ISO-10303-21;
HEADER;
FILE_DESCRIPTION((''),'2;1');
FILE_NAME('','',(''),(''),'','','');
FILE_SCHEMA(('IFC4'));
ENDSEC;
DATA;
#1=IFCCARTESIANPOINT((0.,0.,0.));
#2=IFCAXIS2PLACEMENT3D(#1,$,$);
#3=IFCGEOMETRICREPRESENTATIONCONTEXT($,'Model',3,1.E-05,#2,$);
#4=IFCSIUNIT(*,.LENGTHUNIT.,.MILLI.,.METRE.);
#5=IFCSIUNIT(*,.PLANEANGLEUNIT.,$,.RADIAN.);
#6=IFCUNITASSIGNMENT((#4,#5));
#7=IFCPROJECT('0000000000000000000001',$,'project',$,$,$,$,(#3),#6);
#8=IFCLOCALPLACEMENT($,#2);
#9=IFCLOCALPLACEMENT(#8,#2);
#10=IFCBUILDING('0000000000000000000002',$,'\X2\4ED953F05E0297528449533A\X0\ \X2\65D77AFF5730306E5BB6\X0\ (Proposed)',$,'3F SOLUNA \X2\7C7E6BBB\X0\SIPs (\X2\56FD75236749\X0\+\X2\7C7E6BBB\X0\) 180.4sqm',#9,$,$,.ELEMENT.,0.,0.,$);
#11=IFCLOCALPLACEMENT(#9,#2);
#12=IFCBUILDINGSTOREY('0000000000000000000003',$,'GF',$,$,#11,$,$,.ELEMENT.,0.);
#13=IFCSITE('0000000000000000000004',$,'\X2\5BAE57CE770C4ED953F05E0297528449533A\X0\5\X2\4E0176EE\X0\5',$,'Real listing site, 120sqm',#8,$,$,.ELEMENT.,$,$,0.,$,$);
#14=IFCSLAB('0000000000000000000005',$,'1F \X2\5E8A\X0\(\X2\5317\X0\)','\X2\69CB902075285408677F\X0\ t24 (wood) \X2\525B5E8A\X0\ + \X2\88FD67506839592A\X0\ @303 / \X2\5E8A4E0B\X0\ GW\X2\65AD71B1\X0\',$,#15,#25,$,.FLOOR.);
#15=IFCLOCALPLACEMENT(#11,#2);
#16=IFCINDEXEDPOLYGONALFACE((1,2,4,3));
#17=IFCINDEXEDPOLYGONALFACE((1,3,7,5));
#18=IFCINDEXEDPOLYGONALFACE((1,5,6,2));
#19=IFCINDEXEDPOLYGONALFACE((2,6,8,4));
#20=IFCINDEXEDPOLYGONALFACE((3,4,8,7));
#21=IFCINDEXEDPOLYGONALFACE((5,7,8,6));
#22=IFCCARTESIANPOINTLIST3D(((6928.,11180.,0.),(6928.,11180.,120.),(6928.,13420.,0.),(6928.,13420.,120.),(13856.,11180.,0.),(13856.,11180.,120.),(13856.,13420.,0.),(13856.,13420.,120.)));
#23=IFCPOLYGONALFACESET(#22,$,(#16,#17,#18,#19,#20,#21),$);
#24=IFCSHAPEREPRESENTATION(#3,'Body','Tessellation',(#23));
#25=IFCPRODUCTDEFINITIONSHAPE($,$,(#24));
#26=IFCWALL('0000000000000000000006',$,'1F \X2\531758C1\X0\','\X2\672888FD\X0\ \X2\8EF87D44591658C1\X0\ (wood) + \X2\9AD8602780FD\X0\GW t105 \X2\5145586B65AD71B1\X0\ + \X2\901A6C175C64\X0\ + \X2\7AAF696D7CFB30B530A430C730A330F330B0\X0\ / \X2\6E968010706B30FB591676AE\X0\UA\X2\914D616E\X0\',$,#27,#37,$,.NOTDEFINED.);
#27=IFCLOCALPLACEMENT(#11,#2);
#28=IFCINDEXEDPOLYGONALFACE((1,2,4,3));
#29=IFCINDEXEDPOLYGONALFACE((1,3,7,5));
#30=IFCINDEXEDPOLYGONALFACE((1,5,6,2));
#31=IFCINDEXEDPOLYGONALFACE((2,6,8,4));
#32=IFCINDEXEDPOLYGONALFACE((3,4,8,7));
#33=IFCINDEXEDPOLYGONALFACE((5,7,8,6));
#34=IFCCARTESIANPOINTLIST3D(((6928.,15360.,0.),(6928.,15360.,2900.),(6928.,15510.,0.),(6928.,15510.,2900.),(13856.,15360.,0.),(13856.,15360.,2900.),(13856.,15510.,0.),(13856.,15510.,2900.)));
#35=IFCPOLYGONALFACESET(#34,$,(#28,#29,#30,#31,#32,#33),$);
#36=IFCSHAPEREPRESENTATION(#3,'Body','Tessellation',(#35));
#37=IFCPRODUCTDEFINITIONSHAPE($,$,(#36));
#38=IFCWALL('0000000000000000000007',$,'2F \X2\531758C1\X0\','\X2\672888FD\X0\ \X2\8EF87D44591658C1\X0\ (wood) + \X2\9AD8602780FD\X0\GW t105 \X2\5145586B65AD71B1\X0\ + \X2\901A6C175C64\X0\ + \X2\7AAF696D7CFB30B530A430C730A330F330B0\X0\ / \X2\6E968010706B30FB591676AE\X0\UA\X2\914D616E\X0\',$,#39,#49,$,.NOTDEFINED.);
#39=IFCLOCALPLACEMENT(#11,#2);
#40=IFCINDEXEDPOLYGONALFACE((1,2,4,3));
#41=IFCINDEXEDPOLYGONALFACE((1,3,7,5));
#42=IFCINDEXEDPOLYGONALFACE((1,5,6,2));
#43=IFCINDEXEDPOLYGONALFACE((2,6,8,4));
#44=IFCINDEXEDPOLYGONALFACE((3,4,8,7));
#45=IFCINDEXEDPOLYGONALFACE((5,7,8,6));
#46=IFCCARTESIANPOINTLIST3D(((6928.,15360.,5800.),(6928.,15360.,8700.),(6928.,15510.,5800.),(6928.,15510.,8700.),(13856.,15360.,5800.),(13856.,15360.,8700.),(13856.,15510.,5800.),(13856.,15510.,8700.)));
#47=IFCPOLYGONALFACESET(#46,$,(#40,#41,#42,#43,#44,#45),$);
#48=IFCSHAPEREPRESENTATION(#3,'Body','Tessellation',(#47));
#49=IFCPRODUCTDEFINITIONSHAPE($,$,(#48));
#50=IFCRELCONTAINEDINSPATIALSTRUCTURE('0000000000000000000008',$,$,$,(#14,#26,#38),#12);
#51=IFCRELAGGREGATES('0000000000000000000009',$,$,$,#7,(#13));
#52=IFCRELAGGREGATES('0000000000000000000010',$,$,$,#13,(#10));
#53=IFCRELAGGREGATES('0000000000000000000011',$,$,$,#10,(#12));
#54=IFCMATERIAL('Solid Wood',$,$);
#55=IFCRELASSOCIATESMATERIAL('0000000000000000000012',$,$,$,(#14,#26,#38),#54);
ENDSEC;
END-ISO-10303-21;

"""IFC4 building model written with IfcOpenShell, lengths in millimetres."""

from ifc_helpers import new_model, si_unit, frame, frame_2d, origin, place, context, project, spatial, rectangle, extrude, material, element, save


model = new_model("IFC4")

# Units and contexts
model_context = context("Model", 3, precision=1e-05, world=origin())
ifc_project = project(units=[si_unit("LENGTHUNIT", "METRE", prefix="MILLI"), si_unit("PLANEANGLEUNIT", "RADIAN")], contexts=[model_context])

# Site, building, storey
site_placement = place(None, origin())
site = spatial("IfcSite", under=ifc_project, at=site_placement, Name="宮城県仙台市青葉区5丁目5", ObjectType="Real listing site, 120sqm", CompositionType="ELEMENT", RefElevation=0.0)
building_placement = place(site_placement, origin())
building = spatial("IfcBuilding", under=site, at=building_placement, Name="仙台市青葉区 旗竿地の家 (Proposed)", ObjectType="3F SOLUNA 籾殻SIPs (国産杉+籾殻) 180.4sqm", CompositionType="ELEMENT", ElevationOfRefHeight=0.0, ElevationOfTerrain=0.0)
storey_placement = place(building_placement, origin())
storey = spatial("IfcBuildingStorey", under=building, at=storey_placement, Name="GF", CompositionType="ELEMENT", Elevation=0.0)

# Slab
ifc_material_1 = material(Name="Solid Wood")
slab_1_placement = place(storey_placement, frame((3464.0, 5590.0, 0.0)))
element("IfcSlab", 1, at=slab_1_placement, inside=storey, material=ifc_material_1, Name="1F 床(北)", Description="構造用合板 t24 (wood) 剛床 + 製材根太 @303 / 床下 GW断熱", PredefinedType="FLOOR", context=model_context, shape_type="SweptSolid", body=[
    extrude(rectangle(XDim=6928.0, YDim=2240.0, at=frame_2d((3464.0, 1120.0))), frame((3464.0, 5590.0, 0.0)), (0.0, 0.0, 1.0), 120.0),
])

# Wall
wall_1_placement = place(storey_placement, frame((3464.0, 7680.0, 0.0)))
element("IfcWall", 2, at=wall_1_placement, inside=storey, material=ifc_material_1, Name="1F 北壁", Description="木製 軸組外壁 (wood) + 高性能GW t105 充填断熱 + 通気層 + 窯業系サイディング / 準耐火・外皮UA配慮", PredefinedType="NOTDEFINED", context=model_context, shape_type="SweptSolid", body=[
    extrude(rectangle(XDim=6928.0, YDim=150.0, at=frame_2d((3464.0, 75.0))), frame((3464.0, 7680.0, 0.0)), (0.0, 0.0, 1.0), 2900.0),
])

# Wall
wall_2_placement = place(storey_placement, frame((3464.0, 7680.0, 2900.0)))
element("IfcWall", 3, at=wall_2_placement, inside=storey, material=ifc_material_1, Name="2F 北壁", Description="木製 軸組外壁 (wood) + 高性能GW t105 充填断熱 + 通気層 + 窯業系サイディング / 準耐火・外皮UA配慮", PredefinedType="NOTDEFINED", context=model_context, shape_type="SweptSolid", body=[
    extrude(rectangle(XDim=6928.0, YDim=150.0, at=frame_2d((3464.0, 75.0))), frame((3464.0, 7680.0, 2900.0)), (0.0, 0.0, 1.0), 2900.0),
])

save(model, "model.ifc")
